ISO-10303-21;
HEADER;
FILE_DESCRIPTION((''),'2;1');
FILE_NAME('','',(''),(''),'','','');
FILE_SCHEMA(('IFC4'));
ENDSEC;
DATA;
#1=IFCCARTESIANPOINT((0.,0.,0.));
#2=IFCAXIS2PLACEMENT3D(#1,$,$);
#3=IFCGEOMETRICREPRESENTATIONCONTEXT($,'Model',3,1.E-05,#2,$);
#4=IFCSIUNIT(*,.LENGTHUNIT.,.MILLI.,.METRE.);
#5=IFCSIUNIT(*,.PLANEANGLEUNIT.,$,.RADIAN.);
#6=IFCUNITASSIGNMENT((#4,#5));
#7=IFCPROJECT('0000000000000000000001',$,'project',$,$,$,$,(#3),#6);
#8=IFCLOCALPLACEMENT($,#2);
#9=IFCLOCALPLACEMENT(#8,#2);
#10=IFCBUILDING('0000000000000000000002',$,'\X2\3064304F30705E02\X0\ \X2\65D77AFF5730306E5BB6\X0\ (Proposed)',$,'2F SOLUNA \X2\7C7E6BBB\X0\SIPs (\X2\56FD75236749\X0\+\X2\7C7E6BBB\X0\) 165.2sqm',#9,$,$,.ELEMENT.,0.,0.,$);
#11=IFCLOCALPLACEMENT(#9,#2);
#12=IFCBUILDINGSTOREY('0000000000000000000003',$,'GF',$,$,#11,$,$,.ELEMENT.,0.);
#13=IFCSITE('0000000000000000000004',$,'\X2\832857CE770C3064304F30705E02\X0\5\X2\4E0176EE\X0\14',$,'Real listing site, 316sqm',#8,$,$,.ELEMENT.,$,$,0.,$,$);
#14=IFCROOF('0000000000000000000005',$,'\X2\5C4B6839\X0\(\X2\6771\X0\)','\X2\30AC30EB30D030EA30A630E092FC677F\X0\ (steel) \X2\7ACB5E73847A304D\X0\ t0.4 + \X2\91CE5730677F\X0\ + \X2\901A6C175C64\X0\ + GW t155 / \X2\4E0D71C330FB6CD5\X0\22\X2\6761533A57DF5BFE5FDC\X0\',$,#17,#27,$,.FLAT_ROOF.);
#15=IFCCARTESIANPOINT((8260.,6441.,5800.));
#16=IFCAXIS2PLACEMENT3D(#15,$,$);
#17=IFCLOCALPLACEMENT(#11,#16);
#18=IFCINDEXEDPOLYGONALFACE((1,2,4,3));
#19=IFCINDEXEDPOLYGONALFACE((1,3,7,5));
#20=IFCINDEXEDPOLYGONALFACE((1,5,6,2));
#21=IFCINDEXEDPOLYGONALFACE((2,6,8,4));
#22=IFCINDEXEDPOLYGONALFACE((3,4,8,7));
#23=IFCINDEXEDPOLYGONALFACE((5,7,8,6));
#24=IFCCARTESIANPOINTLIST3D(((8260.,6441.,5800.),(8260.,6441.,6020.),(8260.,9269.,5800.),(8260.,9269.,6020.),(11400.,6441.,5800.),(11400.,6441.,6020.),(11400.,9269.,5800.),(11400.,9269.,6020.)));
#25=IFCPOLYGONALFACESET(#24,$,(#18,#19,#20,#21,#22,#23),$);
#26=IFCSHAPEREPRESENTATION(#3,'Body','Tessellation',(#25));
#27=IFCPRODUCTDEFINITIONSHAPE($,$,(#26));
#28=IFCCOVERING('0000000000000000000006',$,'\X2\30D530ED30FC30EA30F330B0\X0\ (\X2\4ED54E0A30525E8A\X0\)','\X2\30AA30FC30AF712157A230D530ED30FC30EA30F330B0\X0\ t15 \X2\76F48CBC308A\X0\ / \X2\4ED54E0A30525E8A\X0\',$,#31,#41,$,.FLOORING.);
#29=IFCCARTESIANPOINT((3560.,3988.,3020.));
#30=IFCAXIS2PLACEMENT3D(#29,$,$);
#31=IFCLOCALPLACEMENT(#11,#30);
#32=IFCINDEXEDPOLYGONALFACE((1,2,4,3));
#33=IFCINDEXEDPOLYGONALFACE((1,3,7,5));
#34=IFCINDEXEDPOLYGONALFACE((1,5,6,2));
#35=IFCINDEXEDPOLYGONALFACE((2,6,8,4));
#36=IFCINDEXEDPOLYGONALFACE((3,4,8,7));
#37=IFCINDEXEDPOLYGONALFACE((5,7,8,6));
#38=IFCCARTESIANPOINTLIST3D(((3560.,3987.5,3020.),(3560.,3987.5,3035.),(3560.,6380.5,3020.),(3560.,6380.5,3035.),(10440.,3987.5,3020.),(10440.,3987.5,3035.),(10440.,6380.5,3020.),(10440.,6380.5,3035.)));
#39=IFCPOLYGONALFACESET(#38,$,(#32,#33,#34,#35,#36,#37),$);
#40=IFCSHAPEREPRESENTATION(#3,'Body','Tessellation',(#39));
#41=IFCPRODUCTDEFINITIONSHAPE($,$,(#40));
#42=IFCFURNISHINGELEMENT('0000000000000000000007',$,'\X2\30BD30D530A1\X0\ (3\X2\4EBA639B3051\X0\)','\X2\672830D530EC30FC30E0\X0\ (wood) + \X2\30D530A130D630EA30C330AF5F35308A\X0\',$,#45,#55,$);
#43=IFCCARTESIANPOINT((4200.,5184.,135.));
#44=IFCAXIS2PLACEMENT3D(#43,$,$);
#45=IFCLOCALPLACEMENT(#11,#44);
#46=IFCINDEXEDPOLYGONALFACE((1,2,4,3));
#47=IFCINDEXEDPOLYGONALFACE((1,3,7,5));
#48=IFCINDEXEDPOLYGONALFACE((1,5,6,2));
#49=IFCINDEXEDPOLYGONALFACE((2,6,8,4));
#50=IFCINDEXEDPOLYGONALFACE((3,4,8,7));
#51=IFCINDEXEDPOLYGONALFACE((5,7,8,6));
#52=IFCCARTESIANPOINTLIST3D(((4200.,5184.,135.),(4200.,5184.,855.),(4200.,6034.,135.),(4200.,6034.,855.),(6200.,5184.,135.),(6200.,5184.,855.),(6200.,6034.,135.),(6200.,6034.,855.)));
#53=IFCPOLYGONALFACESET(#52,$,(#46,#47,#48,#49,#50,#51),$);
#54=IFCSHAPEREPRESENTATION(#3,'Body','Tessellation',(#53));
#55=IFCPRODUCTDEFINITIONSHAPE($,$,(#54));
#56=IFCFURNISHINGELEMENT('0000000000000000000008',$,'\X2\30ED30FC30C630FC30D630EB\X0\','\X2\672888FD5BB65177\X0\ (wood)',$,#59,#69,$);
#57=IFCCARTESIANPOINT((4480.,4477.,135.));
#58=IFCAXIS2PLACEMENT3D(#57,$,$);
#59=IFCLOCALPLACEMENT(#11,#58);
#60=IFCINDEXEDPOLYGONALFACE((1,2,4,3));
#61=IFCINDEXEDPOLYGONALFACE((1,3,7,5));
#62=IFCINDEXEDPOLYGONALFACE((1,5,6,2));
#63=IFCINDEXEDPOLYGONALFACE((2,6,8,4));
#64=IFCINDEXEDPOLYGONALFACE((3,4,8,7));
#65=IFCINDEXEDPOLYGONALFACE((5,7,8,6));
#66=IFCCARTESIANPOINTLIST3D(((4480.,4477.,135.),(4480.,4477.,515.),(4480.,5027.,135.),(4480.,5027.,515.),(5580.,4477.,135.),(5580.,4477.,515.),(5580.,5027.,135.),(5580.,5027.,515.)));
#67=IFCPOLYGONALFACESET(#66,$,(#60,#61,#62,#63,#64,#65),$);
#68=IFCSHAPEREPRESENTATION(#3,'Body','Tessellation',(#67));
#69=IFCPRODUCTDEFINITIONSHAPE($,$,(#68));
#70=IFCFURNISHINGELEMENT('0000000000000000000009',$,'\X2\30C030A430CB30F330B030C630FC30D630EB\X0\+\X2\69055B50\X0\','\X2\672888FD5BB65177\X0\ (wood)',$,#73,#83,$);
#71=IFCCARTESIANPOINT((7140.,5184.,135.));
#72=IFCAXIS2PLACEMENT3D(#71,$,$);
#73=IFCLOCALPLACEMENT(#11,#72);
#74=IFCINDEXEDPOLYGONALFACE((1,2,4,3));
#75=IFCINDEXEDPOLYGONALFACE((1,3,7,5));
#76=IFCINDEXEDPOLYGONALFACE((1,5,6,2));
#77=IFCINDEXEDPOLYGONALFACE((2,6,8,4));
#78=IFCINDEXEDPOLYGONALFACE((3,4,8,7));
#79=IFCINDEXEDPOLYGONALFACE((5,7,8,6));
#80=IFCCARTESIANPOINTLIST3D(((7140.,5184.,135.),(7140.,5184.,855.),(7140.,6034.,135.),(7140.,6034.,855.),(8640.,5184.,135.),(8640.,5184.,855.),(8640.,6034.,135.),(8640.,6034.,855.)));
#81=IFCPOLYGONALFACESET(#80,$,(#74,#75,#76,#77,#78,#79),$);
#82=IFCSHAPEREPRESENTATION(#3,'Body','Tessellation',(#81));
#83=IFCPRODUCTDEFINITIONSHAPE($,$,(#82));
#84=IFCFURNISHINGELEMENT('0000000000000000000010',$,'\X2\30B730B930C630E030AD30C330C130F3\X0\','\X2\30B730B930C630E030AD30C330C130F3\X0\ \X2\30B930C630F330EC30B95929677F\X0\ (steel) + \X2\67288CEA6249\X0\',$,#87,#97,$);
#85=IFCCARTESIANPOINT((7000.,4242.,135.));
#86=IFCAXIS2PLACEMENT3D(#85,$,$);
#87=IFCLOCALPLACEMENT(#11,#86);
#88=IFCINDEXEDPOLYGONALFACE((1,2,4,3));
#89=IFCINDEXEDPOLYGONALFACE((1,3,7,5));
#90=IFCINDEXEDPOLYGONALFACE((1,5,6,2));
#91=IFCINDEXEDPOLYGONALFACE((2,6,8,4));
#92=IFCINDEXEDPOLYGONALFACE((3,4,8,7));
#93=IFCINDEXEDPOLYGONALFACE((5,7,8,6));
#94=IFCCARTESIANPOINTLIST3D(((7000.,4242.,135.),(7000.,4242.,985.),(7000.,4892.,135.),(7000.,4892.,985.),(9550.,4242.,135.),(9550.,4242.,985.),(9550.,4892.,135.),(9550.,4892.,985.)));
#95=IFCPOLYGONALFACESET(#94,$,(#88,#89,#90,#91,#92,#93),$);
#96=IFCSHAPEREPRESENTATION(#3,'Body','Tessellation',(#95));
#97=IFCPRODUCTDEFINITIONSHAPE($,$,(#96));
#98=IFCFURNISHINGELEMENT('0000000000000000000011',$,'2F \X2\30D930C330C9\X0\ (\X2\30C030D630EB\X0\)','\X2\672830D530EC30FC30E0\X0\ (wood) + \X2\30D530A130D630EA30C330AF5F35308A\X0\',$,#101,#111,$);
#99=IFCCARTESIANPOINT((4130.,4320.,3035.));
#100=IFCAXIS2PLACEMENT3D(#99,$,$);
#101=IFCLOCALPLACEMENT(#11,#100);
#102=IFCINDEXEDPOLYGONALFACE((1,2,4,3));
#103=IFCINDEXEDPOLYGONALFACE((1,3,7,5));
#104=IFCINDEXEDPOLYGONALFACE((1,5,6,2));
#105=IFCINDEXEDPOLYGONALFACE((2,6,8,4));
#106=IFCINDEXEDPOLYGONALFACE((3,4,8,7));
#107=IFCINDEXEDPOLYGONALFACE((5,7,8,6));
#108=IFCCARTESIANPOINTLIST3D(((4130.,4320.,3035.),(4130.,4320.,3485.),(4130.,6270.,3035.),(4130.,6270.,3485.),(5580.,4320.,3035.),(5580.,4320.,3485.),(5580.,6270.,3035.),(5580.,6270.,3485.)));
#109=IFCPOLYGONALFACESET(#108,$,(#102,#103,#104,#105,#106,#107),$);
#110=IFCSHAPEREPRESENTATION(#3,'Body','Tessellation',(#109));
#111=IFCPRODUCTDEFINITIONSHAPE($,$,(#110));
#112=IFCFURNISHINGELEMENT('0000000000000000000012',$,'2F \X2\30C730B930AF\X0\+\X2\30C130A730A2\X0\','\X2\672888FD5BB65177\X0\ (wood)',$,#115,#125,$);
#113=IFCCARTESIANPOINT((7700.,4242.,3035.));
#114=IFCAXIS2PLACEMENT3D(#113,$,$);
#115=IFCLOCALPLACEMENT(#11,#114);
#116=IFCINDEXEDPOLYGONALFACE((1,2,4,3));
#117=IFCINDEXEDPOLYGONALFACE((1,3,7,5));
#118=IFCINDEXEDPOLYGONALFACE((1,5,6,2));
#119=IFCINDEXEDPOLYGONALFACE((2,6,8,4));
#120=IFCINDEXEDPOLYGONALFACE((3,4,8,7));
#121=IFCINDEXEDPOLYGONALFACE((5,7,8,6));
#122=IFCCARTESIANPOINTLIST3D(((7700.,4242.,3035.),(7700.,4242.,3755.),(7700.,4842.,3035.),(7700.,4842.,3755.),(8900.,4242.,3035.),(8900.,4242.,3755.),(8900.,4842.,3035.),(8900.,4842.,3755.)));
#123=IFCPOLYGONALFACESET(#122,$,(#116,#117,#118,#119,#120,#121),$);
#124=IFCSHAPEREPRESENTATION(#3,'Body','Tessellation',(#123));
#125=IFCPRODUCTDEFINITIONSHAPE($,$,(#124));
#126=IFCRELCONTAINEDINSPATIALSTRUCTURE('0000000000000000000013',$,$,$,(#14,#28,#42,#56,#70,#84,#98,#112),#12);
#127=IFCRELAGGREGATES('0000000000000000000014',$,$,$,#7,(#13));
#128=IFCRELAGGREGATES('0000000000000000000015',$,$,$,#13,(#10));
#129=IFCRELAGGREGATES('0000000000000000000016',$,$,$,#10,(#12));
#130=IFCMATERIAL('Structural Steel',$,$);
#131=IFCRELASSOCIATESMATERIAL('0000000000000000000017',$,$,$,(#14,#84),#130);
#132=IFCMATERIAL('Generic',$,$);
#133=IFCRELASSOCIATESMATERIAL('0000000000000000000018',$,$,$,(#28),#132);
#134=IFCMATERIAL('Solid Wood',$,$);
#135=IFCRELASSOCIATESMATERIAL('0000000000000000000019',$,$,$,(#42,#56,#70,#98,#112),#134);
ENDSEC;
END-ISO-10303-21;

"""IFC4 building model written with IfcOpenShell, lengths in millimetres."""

from ifc_helpers import new_model, si_unit, frame, frame_2d, origin, place, context, project, spatial, rectangle, extrude, material, element, save


model = new_model("IFC4")

# Units and contexts
model_context = context("Model", 3, precision=1e-05, world=origin())
ifc_project = project(units=[si_unit("LENGTHUNIT", "METRE", prefix="MILLI"), si_unit("PLANEANGLEUNIT", "RADIAN")], contexts=[model_context])

# Site, building, storey
site_placement = place(None, origin())
site = spatial("IfcSite", under=ifc_project, at=site_placement, Name="茨城県つくば市5丁目14", ObjectType="Real listing site, 316sqm", CompositionType="ELEMENT", RefElevation=0.0)
building_placement = place(site_placement, origin())
building = spatial("IfcBuilding", under=site, at=building_placement, Name="つくば市 旗竿地の家 (Proposed)", ObjectType="2F SOLUNA 籾殻SIPs (国産杉+籾殻) 165.2sqm", CompositionType="ELEMENT", ElevationOfRefHeight=0.0, ElevationOfTerrain=0.0)
storey_placement = place(building_placement, origin())
storey = spatial("IfcBuildingStorey", under=building, at=storey_placement, Name="GF", CompositionType="ELEMENT", Elevation=0.0)

# Shared definitions
ifc_material_1 = material(Name="Solid Wood")

# Shared definitions
ifc_material_2 = material(Name="Generic")

# Roof
ifc_material_3 = material(Name="Structural Steel")
roof_placement = place(storey_placement, frame((8260.0, 6441.0, 5800.0)))
element("IfcRoof", 1, at=roof_placement, inside=storey, material=ifc_material_3, Name="屋根(東)", Description="ガルバリウム鋼板 (steel) 立平葺き t0.4 + 野地板 + 通気層 + GW t155 / 不燃・法22条区域対応", PredefinedType="FLAT_ROOF", context=model_context, shape_type="SweptSolid", body=[
    extrude(rectangle(XDim=3140.0, YDim=2828.0, at=frame_2d((1570.0, 1414.0))), frame((8260.0, 6441.0, 5800.0)), (0.0, 0.0, 1.0), 220.0),
])

# Covering
covering_placement = place(storey_placement, frame((3560.0, 3988.0, 3020.0)))
element("IfcCovering", 2, at=covering_placement, inside=storey, material=ifc_material_2, Name="フローリング (仕上げ床)", Description="オーク無垢フローリング t15 直貼り / 仕上げ床", PredefinedType="FLOORING", context=model_context, shape_type="SweptSolid", body=[
    extrude(rectangle(XDim=6880.0, YDim=2393.0, at=frame_2d((3440.0, 1196.0))), frame((3560.0, 3988.0, 3020.0)), (0.0, 0.0, 1.0), 15.0),
])

# Furnishing elements
furnishing_1_placement = place(storey_placement, frame((4200.0, 5184.0, 135.0)))
element("IfcFurnishingElement", 3, at=furnishing_1_placement, inside=storey, material=ifc_material_1, Name="ソファ (3人掛け)", Description="木フレーム (wood) + ファブリック張り", context=model_context, shape_type="SweptSolid", body=[
    extrude(rectangle(XDim=2000.0, YDim=850.0, at=frame_2d((1000.0, 425.0))), frame((4200.0, 5184.0, 135.0)), (0.0, 0.0, 1.0), 720.0),
])
furnishing_2_placement = place(storey_placement, frame((4480.0, 4477.0, 135.0)))
element("IfcFurnishingElement", 4, at=furnishing_2_placement, inside=storey, material=ifc_material_1, Name="ローテーブル", Description="木製家具 (wood)", context=model_context, shape_type="SweptSolid", body=[
    extrude(rectangle(XDim=1100.0, YDim=550.0, at=frame_2d((550.0, 275.0))), frame((4480.0, 4477.0, 135.0)), (0.0, 0.0, 1.0), 380.0),
])
furnishing_3_placement = place(storey_placement, frame((7140.0, 5184.0, 135.0)))
element("IfcFurnishingElement", 5, at=furnishing_3_placement, inside=storey, material=ifc_material_1, Name="ダイニングテーブル+椅子", Description="木製家具 (wood)", context=model_context, shape_type="SweptSolid", body=[
    extrude(rectangle(XDim=1500.0, YDim=850.0, at=frame_2d((750.0, 425.0))), frame((7140.0, 5184.0, 135.0)), (0.0, 0.0, 1.0), 720.0),
])
furnishing_4_placement = place(storey_placement, frame((7000.0, 4242.0, 135.0)))
element("IfcFurnishingElement", 6, at=furnishing_4_placement, inside=storey, material=ifc_material_3, Name="システムキッチン", Description="システムキッチン ステンレス天板 (steel) + 木質扉", context=model_context, shape_type="SweptSolid", body=[
    extrude(rectangle(XDim=2550.0, YDim=650.0, at=frame_2d((1275.0, 325.0))), frame((7000.0, 4242.0, 135.0)), (0.0, 0.0, 1.0), 850.0),
])
furnishing_5_placement = place(storey_placement, frame((4130.0, 4320.0, 3035.0)))
element("IfcFurnishingElement", 7, at=furnishing_5_placement, inside=storey, material=ifc_material_1, Name="2F ベッド (ダブル)", Description="木フレーム (wood) + ファブリック張り", context=model_context, shape_type="SweptSolid", body=[
    extrude(rectangle(XDim=1450.0, YDim=1950.0, at=frame_2d((725.0, 975.0))), frame((4130.0, 4320.0, 3035.0)), (0.0, 0.0, 1.0), 450.0),
])
furnishing_6_placement = place(storey_placement, frame((7700.0, 4242.0, 3035.0)))
element("IfcFurnishingElement", 8, at=furnishing_6_placement, inside=storey, material=ifc_material_1, Name="2F デスク+チェア", Description="木製家具 (wood)", context=model_context, shape_type="SweptSolid", body=[
    extrude(rectangle(XDim=1200.0, YDim=600.0, at=frame_2d((600.0, 300.0))), frame((7700.0, 4242.0, 3035.0)), (0.0, 0.0, 1.0), 720.0),
])

save(model, "model.ifc")
